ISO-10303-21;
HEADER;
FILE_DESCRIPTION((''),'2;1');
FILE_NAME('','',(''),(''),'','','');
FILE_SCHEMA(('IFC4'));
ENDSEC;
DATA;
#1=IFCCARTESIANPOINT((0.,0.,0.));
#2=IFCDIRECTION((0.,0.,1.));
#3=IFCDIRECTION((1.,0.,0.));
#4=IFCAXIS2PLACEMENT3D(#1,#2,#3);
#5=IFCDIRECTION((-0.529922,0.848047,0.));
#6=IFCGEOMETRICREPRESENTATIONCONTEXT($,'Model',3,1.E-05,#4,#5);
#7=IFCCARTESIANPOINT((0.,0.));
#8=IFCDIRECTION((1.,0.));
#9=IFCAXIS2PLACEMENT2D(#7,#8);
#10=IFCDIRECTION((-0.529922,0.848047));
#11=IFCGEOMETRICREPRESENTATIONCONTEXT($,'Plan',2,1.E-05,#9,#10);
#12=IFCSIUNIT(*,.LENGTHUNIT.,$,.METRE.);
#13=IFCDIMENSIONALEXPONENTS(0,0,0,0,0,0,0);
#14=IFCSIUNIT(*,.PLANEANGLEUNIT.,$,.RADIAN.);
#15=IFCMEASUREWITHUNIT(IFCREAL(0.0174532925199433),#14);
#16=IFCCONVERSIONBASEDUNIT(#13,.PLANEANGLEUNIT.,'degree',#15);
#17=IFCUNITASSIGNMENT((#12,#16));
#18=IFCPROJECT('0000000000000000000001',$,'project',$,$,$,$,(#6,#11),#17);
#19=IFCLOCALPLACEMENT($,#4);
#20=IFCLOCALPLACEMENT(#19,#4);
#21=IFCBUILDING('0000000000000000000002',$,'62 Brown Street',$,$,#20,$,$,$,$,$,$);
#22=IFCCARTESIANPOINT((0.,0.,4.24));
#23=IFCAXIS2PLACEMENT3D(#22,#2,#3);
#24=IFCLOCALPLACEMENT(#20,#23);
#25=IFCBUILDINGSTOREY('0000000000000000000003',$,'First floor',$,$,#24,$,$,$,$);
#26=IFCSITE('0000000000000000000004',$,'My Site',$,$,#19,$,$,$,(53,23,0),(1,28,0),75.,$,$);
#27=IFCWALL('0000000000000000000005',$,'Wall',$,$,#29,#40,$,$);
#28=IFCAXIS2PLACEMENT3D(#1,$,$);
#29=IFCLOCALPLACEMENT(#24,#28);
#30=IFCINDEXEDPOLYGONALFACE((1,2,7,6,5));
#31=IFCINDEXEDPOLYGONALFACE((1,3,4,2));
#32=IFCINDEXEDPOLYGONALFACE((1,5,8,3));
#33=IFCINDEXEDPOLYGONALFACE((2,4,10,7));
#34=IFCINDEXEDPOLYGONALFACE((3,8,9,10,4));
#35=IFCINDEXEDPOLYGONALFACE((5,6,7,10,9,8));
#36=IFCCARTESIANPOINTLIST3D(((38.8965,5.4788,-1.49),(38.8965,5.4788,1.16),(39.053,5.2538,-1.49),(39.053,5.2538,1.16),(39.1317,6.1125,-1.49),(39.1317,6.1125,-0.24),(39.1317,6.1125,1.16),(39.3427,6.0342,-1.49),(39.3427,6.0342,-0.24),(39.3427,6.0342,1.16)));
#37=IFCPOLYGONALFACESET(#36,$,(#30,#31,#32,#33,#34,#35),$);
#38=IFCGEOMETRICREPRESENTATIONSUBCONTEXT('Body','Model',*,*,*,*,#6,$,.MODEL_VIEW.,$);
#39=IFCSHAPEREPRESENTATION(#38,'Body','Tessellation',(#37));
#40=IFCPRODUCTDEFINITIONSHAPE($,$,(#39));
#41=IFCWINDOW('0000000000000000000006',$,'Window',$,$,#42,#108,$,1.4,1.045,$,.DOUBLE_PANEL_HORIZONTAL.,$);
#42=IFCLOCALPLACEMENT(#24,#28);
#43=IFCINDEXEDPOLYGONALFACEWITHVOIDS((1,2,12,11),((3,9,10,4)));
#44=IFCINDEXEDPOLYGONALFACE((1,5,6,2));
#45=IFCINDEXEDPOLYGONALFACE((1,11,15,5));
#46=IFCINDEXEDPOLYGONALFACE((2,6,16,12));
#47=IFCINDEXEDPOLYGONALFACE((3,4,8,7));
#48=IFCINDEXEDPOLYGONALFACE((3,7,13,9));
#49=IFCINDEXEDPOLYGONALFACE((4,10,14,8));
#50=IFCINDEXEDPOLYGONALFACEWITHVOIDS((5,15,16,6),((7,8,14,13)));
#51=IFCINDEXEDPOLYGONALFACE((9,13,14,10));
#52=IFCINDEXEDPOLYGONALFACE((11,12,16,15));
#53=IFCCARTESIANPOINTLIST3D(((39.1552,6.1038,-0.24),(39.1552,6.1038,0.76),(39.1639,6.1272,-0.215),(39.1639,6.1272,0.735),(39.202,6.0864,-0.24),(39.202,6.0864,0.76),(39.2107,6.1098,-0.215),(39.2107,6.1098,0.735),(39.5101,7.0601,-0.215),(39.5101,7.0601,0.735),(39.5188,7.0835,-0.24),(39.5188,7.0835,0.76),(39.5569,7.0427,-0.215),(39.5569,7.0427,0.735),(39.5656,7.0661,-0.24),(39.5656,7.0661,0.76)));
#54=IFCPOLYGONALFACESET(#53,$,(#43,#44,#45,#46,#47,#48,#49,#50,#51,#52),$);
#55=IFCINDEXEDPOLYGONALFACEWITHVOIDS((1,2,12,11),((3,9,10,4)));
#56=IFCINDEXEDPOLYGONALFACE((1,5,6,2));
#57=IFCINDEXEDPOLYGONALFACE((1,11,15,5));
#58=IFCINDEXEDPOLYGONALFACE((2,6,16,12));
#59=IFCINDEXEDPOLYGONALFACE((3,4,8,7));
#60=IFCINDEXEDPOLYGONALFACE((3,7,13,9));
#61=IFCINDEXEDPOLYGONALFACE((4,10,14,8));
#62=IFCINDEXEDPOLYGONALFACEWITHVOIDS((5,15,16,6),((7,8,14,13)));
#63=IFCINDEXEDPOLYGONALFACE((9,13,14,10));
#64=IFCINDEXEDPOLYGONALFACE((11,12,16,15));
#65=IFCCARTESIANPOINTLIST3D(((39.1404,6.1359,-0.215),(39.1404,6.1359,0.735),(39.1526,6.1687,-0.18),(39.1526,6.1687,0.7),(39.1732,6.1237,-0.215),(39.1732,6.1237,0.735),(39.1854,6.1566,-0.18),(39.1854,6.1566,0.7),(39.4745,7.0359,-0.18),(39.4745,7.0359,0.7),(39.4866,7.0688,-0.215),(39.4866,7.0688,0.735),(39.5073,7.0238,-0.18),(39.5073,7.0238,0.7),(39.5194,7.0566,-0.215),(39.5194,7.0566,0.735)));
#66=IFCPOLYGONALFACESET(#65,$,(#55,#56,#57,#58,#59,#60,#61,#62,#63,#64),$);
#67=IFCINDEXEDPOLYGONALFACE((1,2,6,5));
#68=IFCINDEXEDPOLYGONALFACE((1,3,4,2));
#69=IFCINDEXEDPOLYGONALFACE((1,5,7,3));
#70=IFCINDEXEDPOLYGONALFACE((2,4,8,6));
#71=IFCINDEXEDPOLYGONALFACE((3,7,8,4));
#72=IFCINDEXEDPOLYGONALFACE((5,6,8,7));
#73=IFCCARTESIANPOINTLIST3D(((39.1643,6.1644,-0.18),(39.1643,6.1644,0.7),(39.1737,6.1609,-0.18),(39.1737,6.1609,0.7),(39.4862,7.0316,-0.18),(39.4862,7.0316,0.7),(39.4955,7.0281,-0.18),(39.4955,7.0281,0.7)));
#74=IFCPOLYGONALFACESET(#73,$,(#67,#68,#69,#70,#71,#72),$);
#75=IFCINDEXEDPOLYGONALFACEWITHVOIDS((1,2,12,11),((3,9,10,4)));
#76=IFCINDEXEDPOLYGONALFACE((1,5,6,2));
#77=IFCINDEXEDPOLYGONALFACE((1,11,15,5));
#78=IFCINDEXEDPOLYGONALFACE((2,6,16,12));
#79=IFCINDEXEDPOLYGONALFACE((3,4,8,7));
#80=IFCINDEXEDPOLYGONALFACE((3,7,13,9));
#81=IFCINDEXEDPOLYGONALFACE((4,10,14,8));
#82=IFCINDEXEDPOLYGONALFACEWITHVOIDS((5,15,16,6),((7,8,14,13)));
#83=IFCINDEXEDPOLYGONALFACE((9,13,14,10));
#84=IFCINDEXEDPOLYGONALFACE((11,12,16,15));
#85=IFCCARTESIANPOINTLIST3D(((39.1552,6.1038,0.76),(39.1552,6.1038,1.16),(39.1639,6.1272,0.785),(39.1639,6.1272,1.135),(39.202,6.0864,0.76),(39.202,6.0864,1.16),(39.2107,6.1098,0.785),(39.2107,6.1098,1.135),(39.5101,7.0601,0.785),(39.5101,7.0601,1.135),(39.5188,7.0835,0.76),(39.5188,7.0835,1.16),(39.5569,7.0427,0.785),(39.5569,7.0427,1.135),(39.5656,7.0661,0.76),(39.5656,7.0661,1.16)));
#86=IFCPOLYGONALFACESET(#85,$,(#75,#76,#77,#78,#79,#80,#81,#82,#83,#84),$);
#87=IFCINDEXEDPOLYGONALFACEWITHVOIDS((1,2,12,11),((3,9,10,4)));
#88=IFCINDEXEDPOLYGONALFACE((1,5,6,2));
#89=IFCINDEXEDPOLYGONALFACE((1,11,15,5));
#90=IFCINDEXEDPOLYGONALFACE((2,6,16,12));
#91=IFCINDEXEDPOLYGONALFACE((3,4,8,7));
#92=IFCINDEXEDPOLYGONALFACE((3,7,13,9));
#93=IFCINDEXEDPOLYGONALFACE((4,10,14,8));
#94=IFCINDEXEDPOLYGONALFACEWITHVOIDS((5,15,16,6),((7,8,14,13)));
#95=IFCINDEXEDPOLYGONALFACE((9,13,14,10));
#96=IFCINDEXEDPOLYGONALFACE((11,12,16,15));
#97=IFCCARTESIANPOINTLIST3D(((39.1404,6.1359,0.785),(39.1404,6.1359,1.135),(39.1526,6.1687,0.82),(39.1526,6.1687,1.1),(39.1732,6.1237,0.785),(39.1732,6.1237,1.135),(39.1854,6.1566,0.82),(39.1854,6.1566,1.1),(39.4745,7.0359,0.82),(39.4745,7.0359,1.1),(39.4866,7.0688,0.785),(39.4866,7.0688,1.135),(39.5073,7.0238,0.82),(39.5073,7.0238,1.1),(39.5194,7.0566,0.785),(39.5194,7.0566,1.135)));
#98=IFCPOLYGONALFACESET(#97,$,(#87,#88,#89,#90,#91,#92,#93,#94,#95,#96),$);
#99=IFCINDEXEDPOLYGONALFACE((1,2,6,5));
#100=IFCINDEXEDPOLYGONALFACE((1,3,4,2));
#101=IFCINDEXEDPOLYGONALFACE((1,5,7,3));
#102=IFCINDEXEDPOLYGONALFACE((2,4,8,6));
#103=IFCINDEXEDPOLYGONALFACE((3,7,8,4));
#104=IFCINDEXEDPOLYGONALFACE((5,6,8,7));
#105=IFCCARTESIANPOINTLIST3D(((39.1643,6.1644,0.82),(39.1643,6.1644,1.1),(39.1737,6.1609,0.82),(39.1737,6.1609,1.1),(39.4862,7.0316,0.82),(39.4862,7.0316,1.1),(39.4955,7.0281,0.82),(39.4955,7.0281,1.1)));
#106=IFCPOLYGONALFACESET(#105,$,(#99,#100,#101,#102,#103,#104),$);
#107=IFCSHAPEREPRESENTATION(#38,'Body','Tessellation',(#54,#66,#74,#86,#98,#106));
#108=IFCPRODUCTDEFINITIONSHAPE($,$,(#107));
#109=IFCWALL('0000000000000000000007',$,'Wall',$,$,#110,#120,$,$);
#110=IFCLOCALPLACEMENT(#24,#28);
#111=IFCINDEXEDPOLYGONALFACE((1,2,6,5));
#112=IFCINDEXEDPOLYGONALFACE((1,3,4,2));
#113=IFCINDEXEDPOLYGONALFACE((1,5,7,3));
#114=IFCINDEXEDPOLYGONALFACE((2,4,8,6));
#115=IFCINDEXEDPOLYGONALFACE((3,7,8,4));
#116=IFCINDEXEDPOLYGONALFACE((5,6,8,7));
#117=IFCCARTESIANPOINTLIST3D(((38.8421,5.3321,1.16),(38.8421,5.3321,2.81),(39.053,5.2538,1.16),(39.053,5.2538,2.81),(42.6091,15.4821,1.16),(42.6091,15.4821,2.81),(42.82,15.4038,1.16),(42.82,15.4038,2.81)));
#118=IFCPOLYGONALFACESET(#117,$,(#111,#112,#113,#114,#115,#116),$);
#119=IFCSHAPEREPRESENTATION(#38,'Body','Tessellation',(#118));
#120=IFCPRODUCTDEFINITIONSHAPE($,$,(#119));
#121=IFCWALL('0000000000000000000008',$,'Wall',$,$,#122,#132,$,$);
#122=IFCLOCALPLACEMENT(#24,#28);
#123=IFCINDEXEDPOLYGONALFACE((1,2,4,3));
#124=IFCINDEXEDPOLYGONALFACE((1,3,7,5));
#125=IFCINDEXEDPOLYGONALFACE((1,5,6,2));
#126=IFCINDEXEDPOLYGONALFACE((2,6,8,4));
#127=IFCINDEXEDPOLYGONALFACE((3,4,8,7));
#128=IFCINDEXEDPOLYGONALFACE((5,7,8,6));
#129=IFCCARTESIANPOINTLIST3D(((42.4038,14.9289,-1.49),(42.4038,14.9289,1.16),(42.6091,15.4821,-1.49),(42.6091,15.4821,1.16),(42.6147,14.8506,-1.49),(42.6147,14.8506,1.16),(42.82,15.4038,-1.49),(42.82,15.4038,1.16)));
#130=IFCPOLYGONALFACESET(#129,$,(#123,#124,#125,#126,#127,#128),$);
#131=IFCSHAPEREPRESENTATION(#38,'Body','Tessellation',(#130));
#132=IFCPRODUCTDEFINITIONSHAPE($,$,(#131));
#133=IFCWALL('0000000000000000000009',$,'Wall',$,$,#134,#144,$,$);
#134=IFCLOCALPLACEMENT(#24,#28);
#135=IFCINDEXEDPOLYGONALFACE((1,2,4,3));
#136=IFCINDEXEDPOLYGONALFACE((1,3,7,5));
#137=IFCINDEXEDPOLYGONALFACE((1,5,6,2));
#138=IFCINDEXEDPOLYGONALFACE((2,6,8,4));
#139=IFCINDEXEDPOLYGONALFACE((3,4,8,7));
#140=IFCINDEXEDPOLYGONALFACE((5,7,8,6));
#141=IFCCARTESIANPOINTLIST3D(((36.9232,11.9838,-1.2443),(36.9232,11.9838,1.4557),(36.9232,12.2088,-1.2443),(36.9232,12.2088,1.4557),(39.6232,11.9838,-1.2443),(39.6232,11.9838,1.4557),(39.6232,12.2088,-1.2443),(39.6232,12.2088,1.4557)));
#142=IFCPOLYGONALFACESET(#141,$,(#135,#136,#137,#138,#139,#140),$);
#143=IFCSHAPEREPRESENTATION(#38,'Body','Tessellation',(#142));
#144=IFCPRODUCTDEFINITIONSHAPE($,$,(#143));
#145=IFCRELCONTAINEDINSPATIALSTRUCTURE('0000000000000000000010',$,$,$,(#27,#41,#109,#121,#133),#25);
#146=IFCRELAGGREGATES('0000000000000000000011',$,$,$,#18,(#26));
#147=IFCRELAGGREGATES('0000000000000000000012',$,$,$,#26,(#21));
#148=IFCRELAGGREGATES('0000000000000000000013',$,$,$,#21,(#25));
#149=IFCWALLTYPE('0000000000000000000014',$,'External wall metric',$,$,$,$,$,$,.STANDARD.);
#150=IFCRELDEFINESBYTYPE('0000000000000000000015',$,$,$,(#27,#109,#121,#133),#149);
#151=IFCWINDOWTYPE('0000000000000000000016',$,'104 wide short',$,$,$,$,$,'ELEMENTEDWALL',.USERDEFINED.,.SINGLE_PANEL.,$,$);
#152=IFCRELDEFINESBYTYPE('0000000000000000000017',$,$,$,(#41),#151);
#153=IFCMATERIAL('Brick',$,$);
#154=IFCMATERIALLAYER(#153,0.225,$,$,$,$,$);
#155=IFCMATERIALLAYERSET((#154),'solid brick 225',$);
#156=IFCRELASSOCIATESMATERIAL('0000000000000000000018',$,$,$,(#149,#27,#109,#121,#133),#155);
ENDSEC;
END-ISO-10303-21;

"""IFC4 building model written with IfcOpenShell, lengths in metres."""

from ifc_helpers import new_model, entity, si_unit, converted_unit, direction, frame, origin_with_axes, origin_2d_with_axis, place, context, subcontext, project, spatial, line, indexed_curve, outline, extrude, clip, halfspace, shape, source, transform, mapped, material, layer, layer_set, layer_usage, type_object, type_shapes, element, fill, save


model = new_model("IFC4")

# Units and contexts
model_context = context("Model", 3, precision=1e-05, world=origin_with_axes(), true_north=direction((-0.529922, 0.848047, 0.0)))
plan_context = context("Plan", 2, precision=1e-05, world=origin_2d_with_axis(), true_north=direction((-0.529922, 0.848047)))
body_context_1 = subcontext(model_context, "Body", "Model", "MODEL_VIEW")
body_context_2 = subcontext(plan_context, "Body", "Plan", "PLAN_VIEW")
ifc_project = project(units=[si_unit("LENGTHUNIT", "METRE"), converted_unit("PLANEANGLEUNIT", "degree", entity("IfcReal", 0.0174532925199433), si_unit("PLANEANGLEUNIT", "RADIAN"), dimensions=[0, 0, 0, 0, 0, 0, 0])], contexts=[model_context, plan_context])

# Site, building, storey
site_placement = place(None, origin_with_axes())
site = spatial("IfcSite", under=ifc_project, at=site_placement, Name="My Site", RefLatitude=(53, 23, 0), RefLongitude=(1, 28, 0), RefElevation=75.0)
building_placement = place(site_placement, origin_with_axes())
building = spatial("IfcBuilding", under=site, at=building_placement, Name="62 Brown Street")
storey_placement = place(building_placement, frame((0.0, 0.0, 4.24), z_axis=(0.0, 0.0, 1.0), x_axis=(1.0, 0.0, 0.0)))
storey = spatial("IfcBuildingStorey", under=building, at=storey_placement, Name="First floor")

# Wall, opening, window
ifc_material_1 = material(Name="Brick")
ifc_layer_1 = layer(ifc_material_1, 0.225)
ifc_layer_set_1 = layer_set([ifc_layer_1], Name="solid brick 225")
ifc_layer_usage_1 = layer_usage(ifc_layer_set_1, "AXIS2", "POSITIVE", 0.0)
wall_type_1 = type_object("IfcWallType", Name="External wall metric", PredefinedType="STANDARD", material=ifc_layer_set_1)
wall_1_placement = place(storey_placement, frame((39.024, 5.1755, -1.49), z_axis=(0.0, 0.0, 1.0), x_axis=(0.347944, 0.937515, 0.0)))
wall_1 = element("IfcWall", 1, at=wall_1_placement, inside=storey, type_object=wall_type_1, material=ifc_layer_usage_1, Name="Wall", context=body_context_1, shape_type="Clipping", body=[
    clip(extrude(outline(indexed_curve([(0.0, 0.0), (0.0, 0.225), (0.9159, 0.225), (0.9159, 0.0), (0.0, 0.0)], self_intersect=False)), origin_with_axes(), (0.0, 0.0, 1.0), 2.65), halfspace(frame((0.0835, 0.0, -2.75), z_axis=(-0.596248, 0.414701, 0.0), x_axis=(0.156491, 0.224999, 0.0)), False)),
])
shared_shape_1 = source(origin_with_axes(), body_context_1, "Body", "SweptSolid", [
    extrude(outline(indexed_curve([(0.0, 0.0), (1.045, 0.0), (1.045, 1.4), (0.0, 1.4)], segments=[line(1, 2, 3, 4, 1)])), frame((0.0, -0.1, 0.0), z_axis=(0.0, -1.0, 0.0), x_axis=(1.0, 0.0, 0.0)), (0.0, 0.0, -1.0), 0.425),
])
opening_placement = place(wall_1_placement, frame((0.9159, 0.0, 1.25), z_axis=(0.0, 0.0, 1.0), x_axis=(1.0, 0.0, 0.0)))
opening = element("IfcOpeningElement", 2, at=opening_placement, cuts=wall_1, PredefinedType="OPENING", context=body_context_1, shape_type="MappedRepresentation", body=[
    mapped(shared_shape_1, transform((0.0, 0.0, 0.0), x_axis=(1.0, 0.0, 0.0), y_axis=(0.0, 1.0, 0.0), z_axis=(0.0, 0.0, 1.0), scale=1.0)),
])
window_type = type_object("IfcWindowType", Name="104 wide short", ElementType="ELEMENTEDWALL", PartitioningType="SINGLE_PANEL", PredefinedType="USERDEFINED")
shared_shape_2 = source(origin_with_axes(), body_context_1, "Body", "SweptSolid", [
    extrude(outline(indexed_curve([(0.0, 0.0), (1.045, 0.0), (1.045, 1.0), (0.0, 1.0)], segments=[line(1, 2, 3, 4, 1)]), holes=[indexed_curve([(0.025, 0.025), (1.02, 0.025), (1.02, 0.975), (0.025, 0.975)], segments=[line(1, 2, 3, 4, 1)])]), frame((0.0, 0.15, 0.0), z_axis=(0.0, -1.0, 0.0), x_axis=(1.0, 0.0, 0.0)), (0.0, 0.0, -1.0), 0.05),
    extrude(outline(indexed_curve([(0.0, 0.0), (0.995, 0.0), (0.995, 0.95), (0.0, 0.95)], segments=[line(1, 2, 3, 4, 1)]), holes=[indexed_curve([(0.035, 0.035), (0.96, 0.035), (0.96, 0.915), (0.035, 0.915)], segments=[line(1, 2, 3, 4, 1)])]), frame((0.025, 0.19, 0.025), z_axis=(0.0, -1.0, 0.0), x_axis=(1.0, 0.0, 0.0)), (0.0, 0.0, -1.0), 0.035),
    extrude(outline(indexed_curve([(0.035, 0.035), (0.96, 0.035), (0.96, 0.915), (0.035, 0.915)], segments=[line(1, 2, 3, 4, 1)])), frame((0.025, 0.2025, 0.025), z_axis=(0.0, -1.0, 0.0), x_axis=(1.0, 0.0, 0.0)), (0.0, 0.0, -1.0), 0.01),
    extrude(outline(indexed_curve([(0.0, 0.0), (1.045, 0.0), (1.045, 0.4), (0.0, 0.4)], segments=[line(1, 2, 3, 4, 1)]), holes=[indexed_curve([(0.025, 0.025), (1.02, 0.025), (1.02, 0.375), (0.025, 0.375)], segments=[line(1, 2, 3, 4, 1)])]), frame((0.0, 0.15, 1.0), z_axis=(0.0, -1.0, 0.0), x_axis=(1.0, 0.0, 0.0)), (0.0, 0.0, -1.0), 0.05),
    extrude(outline(indexed_curve([(0.0, 0.0), (0.995, 0.0), (0.995, 0.35), (0.0, 0.35)], segments=[line(1, 2, 3, 4, 1)]), holes=[indexed_curve([(0.035, 0.035), (0.96, 0.035), (0.96, 0.315), (0.035, 0.315)], segments=[line(1, 2, 3, 4, 1)])]), frame((0.025, 0.19, 1.025), z_axis=(0.0, -1.0, 0.0), x_axis=(1.0, 0.0, 0.0)), (0.0, 0.0, -1.0), 0.035),
    extrude(outline(indexed_curve([(0.035, 0.035), (0.96, 0.035), (0.96, 0.315), (0.035, 0.315)], segments=[line(1, 2, 3, 4, 1)])), frame((0.025, 0.2025, 1.025), z_axis=(0.0, -1.0, 0.0), x_axis=(1.0, 0.0, 0.0)), (0.0, 0.0, -1.0), 0.01),
])
shared_shape_3 = source(origin_with_axes(), body_context_2, "Body", "Curve2D", [
    entity("IfcIndexedPolyCurve", entity("IfcCartesianPointList2D", [[0.025, 0.15], [1.02, 0.15]])),
    entity("IfcIndexedPolyCurve", entity("IfcCartesianPointList2D", [[0.0, 0.2], [0.025, 0.2], [0.025, 0.15], [0.0, 0.15]]), [entity("IfcLineIndex", [1, 2, 3, 4, 1])]),
    entity("IfcIndexedPolyCurve", entity("IfcCartesianPointList2D", [[1.045, 0.2], [1.02, 0.2], [1.02, 0.15], [1.045, 0.15]]), [entity("IfcLineIndex", [1, 2, 3, 4, 1])]),
    entity("IfcIndexedPolyCurve", entity("IfcCartesianPointList2D", [[0.025, 0.19], [0.06, 0.19], [0.06, 0.225], [0.025, 0.225]]), [entity("IfcLineIndex", [1, 2, 3, 4, 1])]),
    entity("IfcIndexedPolyCurve", entity("IfcCartesianPointList2D", [[1.02, 0.19], [0.985, 0.19], [0.985, 0.225], [1.02, 0.225]]), [entity("IfcLineIndex", [1, 2, 3, 4, 1])]),
    entity("IfcIndexedPolyCurve", entity("IfcCartesianPointList2D", [[0.06, 0.19], [0.985, 0.19]])),
    entity("IfcIndexedPolyCurve", entity("IfcCartesianPointList2D", [[0.06, 0.225], [0.985, 0.225]])),
    entity("IfcIndexedPolyCurve", entity("IfcCartesianPointList2D", [[0.06, 0.2075], [0.985, 0.2075]])),
])
type_shapes(window_type, [shared_shape_2, shared_shape_3])
window_1_placement = place(opening_placement, frame((0.0, 0.0, 0.0), z_axis=(0.0, 0.0, 1.0), x_axis=(1.0, 0.0, 0.0)))
window_1 = element("IfcWindow", 3, at=window_1_placement, inside=storey, type_object=window_type, Name="Window", OverallHeight=1.4, OverallWidth=1.045, PartitioningType="DOUBLE_PANEL_HORIZONTAL", shapes=[
    shape(body_context_1, "Body", "MappedRepresentation", [mapped(shared_shape_2, transform((0.0, 0.0, 0.0), x_axis=(1.0, 0.0, 0.0), y_axis=(0.0, 1.0, 0.0), z_axis=(0.0, 0.0, 1.0), scale=1.0))]),
    shape(body_context_2, "Body", "MappedRepresentation", [mapped(shared_shape_3, transform((0.0, 0.0, 0.0), x_axis=(1.0, 0.0, 0.0), y_axis=(0.0, 1.0, 0.0), z_axis=(0.0, 0.0, 1.0), scale=1.0))]),
])
fill(opening, window_1)

# Walls
ifc_layer_usage_2 = layer_usage(ifc_layer_set_1, "AXIS2", "POSITIVE", 0.0)
wall_2_placement = place(storey_placement, frame((39.053, 5.2538, 1.16), z_axis=(0.0, 0.0, 1.0), x_axis=(0.347944, 0.937515, 0.0)))
element("IfcWall", 4, at=wall_2_placement, inside=storey, type_object=wall_type_1, material=ifc_layer_usage_2, Name="Wall", context=body_context_1, shape_type="SweptSolid", body=[
    extrude(outline(indexed_curve([(0.0, 0.0), (0.0, 0.225), (10.8265, 0.225), (10.8265, 0.0), (0.0, 0.0)], self_intersect=False)), origin_with_axes(), (0.0, 0.0, 1.0), 1.65),
])
ifc_layer_usage_3 = layer_usage(ifc_layer_set_1, "AXIS2", "POSITIVE", 0.0)
wall_3_placement = place(storey_placement, frame((42.6147, 14.8506, -1.49), z_axis=(0.0, 0.0, 1.0), x_axis=(0.347944, 0.937515, 0.0)))
element("IfcWall", 5, at=wall_3_placement, inside=storey, type_object=wall_type_1, material=ifc_layer_usage_3, Name="Wall", context=body_context_1, shape_type="SweptSolid", body=[
    extrude(outline(indexed_curve([(0.0, 0.0), (0.0, 0.225), (0.5901, 0.225), (0.5901, 0.0), (0.0, 0.0)], self_intersect=False)), origin_with_axes(), (0.0, 0.0, 1.0), 2.65),
])
ifc_layer_usage_4 = layer_usage(ifc_layer_set_1, "AXIS2", "POSITIVE", 0.0)
wall_4_placement = place(storey_placement, frame((36.9232, 11.9838, -1.2443), z_axis=(0.0, 0.0, 1.0), x_axis=(1.0, 0.0, 0.0)))
element("IfcWall", 6, at=wall_4_placement, inside=storey, type_object=wall_type_1, material=ifc_layer_usage_4, Name="Wall", context=body_context_1, shape_type="SweptSolid", body=[
    extrude(outline(indexed_curve([(0.0, 0.0), (0.0, 0.225), (2.7, 0.225), (2.7, 0.0), (0.0, 0.0)], self_intersect=False)), origin_with_axes(), (0.0, 0.0, 1.0), 2.7),
])

save(model, "model.ifc")
